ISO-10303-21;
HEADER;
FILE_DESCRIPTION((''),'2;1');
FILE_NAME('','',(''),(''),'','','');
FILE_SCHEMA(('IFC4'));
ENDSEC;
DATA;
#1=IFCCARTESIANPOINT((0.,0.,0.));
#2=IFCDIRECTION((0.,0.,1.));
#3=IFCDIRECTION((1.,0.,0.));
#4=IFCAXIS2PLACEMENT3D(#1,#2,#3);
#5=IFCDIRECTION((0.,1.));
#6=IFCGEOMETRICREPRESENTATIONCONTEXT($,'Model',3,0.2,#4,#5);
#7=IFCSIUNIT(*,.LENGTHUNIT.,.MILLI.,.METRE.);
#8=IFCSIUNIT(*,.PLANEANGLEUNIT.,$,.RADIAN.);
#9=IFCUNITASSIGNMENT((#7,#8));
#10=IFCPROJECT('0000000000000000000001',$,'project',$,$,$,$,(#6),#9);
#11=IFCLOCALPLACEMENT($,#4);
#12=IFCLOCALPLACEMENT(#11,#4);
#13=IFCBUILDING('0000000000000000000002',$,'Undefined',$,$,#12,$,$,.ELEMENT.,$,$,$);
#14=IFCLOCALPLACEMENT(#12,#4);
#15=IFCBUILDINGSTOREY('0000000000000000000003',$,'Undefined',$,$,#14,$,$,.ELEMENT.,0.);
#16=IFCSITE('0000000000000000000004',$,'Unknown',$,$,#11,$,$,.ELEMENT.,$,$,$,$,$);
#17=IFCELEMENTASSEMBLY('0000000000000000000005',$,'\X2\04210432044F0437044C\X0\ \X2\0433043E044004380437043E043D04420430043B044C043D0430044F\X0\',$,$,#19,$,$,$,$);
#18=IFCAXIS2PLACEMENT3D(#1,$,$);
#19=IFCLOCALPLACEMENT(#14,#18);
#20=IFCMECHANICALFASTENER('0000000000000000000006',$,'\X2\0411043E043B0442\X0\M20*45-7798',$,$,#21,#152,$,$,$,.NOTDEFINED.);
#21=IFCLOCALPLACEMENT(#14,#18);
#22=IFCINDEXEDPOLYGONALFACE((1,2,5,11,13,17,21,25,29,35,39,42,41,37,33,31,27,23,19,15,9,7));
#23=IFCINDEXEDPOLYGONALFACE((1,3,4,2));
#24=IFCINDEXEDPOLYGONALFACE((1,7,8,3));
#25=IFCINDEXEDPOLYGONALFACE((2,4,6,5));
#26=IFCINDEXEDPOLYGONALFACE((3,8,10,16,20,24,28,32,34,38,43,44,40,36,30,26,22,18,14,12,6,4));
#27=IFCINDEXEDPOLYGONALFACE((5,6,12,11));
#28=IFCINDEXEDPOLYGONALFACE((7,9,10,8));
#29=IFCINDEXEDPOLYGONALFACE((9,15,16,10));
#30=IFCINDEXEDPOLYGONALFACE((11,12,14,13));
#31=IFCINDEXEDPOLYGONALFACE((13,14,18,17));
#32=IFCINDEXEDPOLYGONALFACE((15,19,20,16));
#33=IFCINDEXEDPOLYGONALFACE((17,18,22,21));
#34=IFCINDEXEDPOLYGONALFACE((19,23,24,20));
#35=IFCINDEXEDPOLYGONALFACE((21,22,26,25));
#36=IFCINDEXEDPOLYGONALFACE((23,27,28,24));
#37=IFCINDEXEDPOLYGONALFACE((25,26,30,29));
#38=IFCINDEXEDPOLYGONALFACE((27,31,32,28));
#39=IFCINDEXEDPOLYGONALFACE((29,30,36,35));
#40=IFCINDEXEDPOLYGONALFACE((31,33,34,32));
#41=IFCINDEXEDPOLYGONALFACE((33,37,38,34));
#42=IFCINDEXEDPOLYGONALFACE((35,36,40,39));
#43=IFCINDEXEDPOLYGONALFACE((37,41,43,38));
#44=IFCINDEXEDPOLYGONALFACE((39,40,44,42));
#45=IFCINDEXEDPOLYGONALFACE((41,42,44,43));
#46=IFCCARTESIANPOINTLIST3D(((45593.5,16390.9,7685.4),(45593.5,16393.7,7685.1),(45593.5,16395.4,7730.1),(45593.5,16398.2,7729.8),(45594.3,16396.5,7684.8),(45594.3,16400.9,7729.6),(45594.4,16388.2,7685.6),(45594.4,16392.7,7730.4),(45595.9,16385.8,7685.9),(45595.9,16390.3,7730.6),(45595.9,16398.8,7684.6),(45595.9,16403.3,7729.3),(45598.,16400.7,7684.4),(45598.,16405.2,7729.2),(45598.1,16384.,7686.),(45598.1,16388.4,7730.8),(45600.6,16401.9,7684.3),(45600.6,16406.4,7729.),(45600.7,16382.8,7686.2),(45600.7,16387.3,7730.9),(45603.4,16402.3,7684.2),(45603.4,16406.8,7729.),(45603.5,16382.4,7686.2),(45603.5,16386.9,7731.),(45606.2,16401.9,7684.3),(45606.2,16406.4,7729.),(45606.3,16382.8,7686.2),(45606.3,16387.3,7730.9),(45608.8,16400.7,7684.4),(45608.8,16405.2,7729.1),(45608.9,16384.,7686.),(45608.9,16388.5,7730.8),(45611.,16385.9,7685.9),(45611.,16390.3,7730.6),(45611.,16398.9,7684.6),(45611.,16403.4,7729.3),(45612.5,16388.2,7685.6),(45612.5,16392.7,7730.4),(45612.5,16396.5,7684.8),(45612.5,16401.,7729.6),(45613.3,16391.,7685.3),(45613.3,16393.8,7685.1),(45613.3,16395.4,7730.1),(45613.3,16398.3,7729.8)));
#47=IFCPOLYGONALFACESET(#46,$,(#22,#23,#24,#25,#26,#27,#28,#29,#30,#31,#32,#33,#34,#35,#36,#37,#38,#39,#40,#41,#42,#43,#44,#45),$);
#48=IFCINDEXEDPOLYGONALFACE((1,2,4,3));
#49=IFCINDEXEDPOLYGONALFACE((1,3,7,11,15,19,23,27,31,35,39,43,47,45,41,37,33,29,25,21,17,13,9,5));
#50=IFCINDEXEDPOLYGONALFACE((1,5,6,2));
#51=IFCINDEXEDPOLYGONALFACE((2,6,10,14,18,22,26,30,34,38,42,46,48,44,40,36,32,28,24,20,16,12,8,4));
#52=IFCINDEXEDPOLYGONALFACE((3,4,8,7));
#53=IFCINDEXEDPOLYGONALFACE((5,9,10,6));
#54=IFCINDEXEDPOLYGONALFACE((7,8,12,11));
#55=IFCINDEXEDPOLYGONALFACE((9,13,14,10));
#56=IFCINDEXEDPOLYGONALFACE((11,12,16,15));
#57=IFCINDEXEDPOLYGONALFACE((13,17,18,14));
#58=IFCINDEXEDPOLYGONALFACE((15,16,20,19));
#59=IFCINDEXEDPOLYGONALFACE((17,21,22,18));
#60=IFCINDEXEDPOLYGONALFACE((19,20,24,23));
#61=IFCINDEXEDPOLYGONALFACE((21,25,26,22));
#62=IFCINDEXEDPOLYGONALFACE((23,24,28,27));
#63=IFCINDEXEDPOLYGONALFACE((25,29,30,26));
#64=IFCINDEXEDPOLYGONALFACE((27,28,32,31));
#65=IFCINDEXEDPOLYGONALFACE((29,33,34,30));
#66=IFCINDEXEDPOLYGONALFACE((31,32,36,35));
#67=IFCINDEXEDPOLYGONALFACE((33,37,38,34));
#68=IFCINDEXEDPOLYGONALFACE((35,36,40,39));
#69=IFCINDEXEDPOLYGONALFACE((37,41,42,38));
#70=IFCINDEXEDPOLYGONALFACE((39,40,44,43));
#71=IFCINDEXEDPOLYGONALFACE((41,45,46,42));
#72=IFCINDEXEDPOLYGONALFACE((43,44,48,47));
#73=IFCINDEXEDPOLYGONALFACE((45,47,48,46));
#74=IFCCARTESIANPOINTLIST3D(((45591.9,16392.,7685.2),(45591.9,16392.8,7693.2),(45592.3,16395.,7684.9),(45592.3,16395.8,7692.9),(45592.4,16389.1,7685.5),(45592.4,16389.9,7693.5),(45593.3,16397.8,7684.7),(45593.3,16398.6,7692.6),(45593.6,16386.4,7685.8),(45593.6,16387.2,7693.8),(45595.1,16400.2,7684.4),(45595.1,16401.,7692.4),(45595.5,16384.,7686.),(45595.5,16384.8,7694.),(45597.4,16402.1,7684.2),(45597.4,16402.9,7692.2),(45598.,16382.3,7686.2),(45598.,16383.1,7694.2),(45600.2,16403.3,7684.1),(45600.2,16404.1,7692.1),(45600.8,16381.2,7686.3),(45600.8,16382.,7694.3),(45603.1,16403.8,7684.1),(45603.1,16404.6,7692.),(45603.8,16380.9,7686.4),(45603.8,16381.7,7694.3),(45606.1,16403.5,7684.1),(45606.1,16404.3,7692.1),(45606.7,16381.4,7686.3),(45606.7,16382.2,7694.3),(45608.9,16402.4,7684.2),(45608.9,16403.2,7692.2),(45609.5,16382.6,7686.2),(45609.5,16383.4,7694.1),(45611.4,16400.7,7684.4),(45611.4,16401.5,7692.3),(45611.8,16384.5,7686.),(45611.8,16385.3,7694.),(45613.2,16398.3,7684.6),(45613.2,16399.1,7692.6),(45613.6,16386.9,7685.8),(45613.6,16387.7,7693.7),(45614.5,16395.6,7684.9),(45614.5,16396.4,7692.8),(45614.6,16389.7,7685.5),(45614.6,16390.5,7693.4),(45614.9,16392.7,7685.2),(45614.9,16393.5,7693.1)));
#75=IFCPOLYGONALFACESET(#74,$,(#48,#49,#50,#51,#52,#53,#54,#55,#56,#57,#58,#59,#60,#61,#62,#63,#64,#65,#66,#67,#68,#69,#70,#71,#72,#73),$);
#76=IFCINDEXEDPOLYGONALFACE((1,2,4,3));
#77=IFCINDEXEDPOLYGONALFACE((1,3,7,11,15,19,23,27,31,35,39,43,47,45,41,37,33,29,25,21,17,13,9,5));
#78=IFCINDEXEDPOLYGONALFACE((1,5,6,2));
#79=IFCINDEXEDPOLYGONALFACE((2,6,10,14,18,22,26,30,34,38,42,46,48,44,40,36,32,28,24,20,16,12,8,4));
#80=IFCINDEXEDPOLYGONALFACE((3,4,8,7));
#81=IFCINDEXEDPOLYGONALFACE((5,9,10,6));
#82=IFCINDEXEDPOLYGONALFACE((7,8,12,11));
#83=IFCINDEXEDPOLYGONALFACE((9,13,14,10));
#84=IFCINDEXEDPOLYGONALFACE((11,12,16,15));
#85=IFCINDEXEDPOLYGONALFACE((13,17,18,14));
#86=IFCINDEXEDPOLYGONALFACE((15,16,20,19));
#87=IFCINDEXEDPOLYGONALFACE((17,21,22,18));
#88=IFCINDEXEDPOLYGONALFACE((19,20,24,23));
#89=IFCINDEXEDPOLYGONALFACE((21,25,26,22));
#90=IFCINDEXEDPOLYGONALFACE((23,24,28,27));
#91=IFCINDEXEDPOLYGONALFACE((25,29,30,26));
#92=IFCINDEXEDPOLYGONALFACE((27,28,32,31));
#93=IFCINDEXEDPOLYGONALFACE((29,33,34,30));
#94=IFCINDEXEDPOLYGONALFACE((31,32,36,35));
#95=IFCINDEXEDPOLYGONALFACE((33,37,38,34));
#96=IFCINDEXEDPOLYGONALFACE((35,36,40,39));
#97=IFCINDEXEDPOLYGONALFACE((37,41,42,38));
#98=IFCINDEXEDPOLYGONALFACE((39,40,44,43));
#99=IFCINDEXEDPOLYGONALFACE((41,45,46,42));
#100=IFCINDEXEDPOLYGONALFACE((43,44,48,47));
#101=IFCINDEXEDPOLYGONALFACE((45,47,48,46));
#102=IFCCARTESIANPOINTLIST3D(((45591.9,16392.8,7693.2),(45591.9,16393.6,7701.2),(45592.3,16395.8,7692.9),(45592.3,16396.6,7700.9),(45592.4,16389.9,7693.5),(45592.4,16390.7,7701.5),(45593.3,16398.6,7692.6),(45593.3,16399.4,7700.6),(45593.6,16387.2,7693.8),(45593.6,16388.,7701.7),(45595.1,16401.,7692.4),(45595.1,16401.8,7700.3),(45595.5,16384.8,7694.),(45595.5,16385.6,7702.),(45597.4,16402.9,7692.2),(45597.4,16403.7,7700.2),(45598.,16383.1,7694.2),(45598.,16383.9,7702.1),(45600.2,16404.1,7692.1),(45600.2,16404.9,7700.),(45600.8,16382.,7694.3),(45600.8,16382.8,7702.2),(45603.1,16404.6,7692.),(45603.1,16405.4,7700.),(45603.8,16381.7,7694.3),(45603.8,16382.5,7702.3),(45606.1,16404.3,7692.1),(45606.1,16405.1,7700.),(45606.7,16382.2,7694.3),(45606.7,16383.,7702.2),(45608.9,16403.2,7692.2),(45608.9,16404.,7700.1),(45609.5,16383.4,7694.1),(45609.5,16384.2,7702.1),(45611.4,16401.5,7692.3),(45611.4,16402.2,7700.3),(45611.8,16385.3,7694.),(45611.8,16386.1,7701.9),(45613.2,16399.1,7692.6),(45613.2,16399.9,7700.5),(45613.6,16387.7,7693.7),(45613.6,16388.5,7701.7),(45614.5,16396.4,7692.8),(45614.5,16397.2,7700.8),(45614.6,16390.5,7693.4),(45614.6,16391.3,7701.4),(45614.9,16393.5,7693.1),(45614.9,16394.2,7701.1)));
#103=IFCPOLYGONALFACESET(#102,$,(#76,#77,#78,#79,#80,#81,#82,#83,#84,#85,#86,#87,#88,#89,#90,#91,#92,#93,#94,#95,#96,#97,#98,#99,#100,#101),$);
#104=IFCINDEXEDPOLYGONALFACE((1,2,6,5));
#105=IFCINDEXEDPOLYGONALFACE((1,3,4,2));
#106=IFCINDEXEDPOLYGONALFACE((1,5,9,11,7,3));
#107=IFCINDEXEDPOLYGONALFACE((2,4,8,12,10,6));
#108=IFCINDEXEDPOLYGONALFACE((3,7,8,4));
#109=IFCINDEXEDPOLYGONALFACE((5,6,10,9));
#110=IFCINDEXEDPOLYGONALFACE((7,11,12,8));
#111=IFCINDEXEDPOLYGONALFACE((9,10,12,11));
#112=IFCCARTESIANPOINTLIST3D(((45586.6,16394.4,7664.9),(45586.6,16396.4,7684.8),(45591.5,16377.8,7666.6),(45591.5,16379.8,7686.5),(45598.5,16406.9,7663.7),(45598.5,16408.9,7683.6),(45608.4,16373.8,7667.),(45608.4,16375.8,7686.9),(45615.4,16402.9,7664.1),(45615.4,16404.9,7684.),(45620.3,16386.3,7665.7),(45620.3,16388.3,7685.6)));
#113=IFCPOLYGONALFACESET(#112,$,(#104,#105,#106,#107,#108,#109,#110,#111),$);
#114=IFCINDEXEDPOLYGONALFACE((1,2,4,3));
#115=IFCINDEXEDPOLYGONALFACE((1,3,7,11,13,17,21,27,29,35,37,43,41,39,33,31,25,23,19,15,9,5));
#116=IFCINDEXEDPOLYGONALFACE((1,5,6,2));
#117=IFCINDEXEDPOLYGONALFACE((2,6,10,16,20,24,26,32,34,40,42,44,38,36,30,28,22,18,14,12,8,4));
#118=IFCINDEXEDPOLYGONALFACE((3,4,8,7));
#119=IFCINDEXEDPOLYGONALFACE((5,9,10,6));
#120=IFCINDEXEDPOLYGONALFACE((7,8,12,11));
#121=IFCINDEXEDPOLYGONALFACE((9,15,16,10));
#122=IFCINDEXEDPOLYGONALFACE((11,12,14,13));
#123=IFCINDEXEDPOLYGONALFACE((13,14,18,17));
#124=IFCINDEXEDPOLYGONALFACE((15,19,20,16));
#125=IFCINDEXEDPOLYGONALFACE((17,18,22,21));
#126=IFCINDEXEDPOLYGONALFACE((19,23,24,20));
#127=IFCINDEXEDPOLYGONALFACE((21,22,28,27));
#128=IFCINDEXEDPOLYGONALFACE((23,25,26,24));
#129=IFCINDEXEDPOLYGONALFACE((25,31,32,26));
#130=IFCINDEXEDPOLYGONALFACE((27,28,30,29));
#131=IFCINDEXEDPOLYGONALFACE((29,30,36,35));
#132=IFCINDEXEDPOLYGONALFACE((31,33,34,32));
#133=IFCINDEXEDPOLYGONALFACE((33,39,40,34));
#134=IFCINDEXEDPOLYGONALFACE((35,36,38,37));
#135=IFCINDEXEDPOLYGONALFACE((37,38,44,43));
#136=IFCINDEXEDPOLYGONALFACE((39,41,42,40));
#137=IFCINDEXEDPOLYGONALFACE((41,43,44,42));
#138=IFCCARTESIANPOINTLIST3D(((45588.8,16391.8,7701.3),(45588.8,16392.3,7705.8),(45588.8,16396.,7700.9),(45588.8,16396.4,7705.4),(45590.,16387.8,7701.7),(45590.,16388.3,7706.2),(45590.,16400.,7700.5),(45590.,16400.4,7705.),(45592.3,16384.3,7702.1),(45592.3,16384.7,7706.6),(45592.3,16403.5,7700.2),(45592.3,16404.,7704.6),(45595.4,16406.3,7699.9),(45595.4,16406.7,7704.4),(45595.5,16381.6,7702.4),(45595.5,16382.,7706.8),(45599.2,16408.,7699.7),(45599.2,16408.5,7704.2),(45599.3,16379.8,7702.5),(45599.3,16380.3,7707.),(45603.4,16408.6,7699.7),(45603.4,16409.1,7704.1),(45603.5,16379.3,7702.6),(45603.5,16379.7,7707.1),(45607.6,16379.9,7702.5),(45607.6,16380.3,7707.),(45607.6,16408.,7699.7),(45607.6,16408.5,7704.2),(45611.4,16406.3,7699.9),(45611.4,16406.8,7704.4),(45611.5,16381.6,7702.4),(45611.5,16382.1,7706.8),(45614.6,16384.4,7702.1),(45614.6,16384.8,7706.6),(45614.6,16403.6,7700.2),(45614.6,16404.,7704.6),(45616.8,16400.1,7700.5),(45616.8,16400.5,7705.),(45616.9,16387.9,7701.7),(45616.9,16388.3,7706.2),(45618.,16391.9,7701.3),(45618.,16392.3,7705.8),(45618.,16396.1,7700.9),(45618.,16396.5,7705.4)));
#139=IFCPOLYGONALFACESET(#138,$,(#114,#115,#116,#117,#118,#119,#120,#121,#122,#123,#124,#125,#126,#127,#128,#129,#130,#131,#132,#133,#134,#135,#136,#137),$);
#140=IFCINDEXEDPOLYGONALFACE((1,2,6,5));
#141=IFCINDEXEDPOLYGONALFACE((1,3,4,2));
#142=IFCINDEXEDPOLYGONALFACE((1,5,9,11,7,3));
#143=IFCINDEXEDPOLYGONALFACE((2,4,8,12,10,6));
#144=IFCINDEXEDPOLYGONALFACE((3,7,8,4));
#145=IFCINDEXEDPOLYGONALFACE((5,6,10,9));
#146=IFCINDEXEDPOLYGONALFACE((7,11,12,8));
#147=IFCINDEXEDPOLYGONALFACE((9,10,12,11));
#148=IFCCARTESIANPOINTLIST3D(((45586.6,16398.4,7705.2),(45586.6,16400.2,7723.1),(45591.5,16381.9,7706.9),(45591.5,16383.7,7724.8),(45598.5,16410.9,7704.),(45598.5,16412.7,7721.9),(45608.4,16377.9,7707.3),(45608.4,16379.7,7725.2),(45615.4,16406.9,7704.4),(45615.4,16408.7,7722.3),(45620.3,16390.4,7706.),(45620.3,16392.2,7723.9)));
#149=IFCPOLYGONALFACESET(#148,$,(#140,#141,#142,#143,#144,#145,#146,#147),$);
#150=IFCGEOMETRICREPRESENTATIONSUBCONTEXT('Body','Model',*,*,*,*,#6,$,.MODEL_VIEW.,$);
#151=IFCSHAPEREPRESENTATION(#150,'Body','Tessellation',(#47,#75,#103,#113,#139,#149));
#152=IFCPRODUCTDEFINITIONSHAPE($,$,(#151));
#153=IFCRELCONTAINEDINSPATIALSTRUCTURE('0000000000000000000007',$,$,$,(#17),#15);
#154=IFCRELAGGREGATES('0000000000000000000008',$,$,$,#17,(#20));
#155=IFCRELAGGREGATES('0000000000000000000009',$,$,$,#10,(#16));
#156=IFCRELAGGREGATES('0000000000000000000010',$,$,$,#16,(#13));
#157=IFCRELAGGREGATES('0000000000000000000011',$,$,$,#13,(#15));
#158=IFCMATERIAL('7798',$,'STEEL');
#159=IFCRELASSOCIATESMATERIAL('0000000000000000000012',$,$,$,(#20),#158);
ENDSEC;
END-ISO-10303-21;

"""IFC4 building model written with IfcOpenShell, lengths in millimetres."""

from ifc_helpers import new_model, si_unit, direction, frame, origin_with_axes, place, context, subcontext, project, spatial, line, arc, indexed_curve, outline, extrude, source, transform, mapped, material, element, aggregate, save


model = new_model("IFC4")

# Units and contexts
model_context = context("Model", 3, precision=0.2, world=origin_with_axes(), true_north=direction((0.0, 1.0)))
body_context = subcontext(model_context, "Body", "Model", "MODEL_VIEW")
ifc_project = project(units=[si_unit("LENGTHUNIT", "METRE", prefix="MILLI"), si_unit("PLANEANGLEUNIT", "RADIAN")], contexts=[model_context])

# Site, building, storey
site_placement = place(None, origin_with_axes())
site = spatial("IfcSite", under=ifc_project, at=site_placement, Name="Unknown", CompositionType="ELEMENT")
building_placement = place(site_placement, origin_with_axes())
building = spatial("IfcBuilding", under=site, at=building_placement, Name="Undefined", CompositionType="ELEMENT")
storey_placement = place(building_placement, origin_with_axes())
storey = spatial("IfcBuildingStorey", under=building, at=storey_placement, Name="Undefined", CompositionType="ELEMENT", Elevation=0.0)

# Element assembly
assembly_1_placement = place(storey_placement, frame((44657.9, 16114.1, 7725.1), z_axis=(0.28473, -0.95385, 0.095385), x_axis=(0.958608, 0.283317, -0.028332)))
assembly_1 = element("IfcElementAssembly", 1, at=assembly_1_placement, inside=storey, Name="Связь горизонтальная")

# Mechanical fastener
ifc_material_1 = material(Name="7798", Category="STEEL")
shared_shape_1 = source(origin_with_axes(), body_context, "Body", "SweptSolid", [
    extrude(outline(indexed_curve([(10.0, 0.0), (0.0, 10.0), (-10.0, 0.0), (0.0, -10.0)], segments=[arc(1, 2, 3), arc(3, 4, 1)])), frame((0.0, 0.0, 12.0), z_axis=(0.0, 0.0, -1.0), x_axis=(0.0, 1.0, 0.0)), (0.0, 0.0, 1.0), 45.0),
    extrude(outline(indexed_curve([(0.0, 11.5), (8.1, 8.1), (11.5, 0.0), (8.1, -8.1), (0.0, -11.5), (-1.0, -11.5), (-11.5, 0.0), (-8.1, 8.1)], segments=[arc(1, 2, 3), arc(3, 4, 5), arc(5, 6, 7), arc(7, 8, 1)])), frame((0.0, 0.0, 12.0), z_axis=(0.0, 0.0, -1.0), x_axis=(0.0, 1.0, 0.0)), (0.0, 0.0, 1.0), 8.0),
    extrude(outline(indexed_curve([(0.0, 11.5), (8.1, 8.1), (11.5, 0.0), (8.1, -8.1), (0.0, -11.5), (-1.0, -11.5), (-11.5, 0.0), (-8.1, 8.1)], segments=[arc(1, 2, 3), arc(3, 4, 5), arc(5, 6, 7), arc(7, 8, 1)])), frame((0.0, 0.0, 4.0), z_axis=(0.0, 0.0, -1.0), x_axis=(0.0, 1.0, 0.0)), (0.0, 0.0, 1.0), 8.0),
    extrude(outline(indexed_curve([(17.3, 0.0), (8.7, 15.0), (-8.7, 15.0), (-17.3, 0.0), (-8.7, -15.0), (8.7, -15.0)], segments=[line(1, 2, 3, 4, 5, 6, 1)])), frame((0.0, 0.0, 32.0), z_axis=(0.0, 0.0, -1.0), x_axis=(0.0, 1.0, 0.0)), (0.0, 0.0, 1.0), 20.0),
    extrude(outline(indexed_curve([(14.8, 0.0), (0.0, 14.8), (-14.8, 0.0), (0.0, -14.8)], segments=[arc(1, 2, 3), arc(3, 4, 1)])), frame((0.0, 0.0, -4.0), z_axis=(0.0, 0.0, -1.0), x_axis=(0.0, 1.0, 0.0)), (0.0, 0.0, 1.0), 4.5),
    extrude(outline(indexed_curve([(17.3, 0.0), (8.7, 15.0), (-8.7, 15.0), (-17.3, 0.0), (-8.7, -15.0), (8.7, -15.0)], segments=[line(1, 2, 3, 4, 5, 6, 1)])), frame((0.0, 0.0, -8.5), z_axis=(0.0, 0.0, -1.0), x_axis=(0.0, 1.0, 0.0)), (0.0, 0.0, 1.0), 18.0),
])
mechanical_fastener_1_placement = place(assembly_1_placement, frame((986.3, 0.0, 0.0), z_axis=(0.0, -1.0, 0.0), x_axis=(-1.0, 0.0, 0.0)))
mechanical_fastener_1 = element("IfcMechanicalFastener", 2, at=mechanical_fastener_1_placement, material=ifc_material_1, Name="БолтM20*45-7798", PredefinedType="NOTDEFINED", context=body_context, shape_type="MappedRepresentation", body=[
    mapped(shared_shape_1, transform((0.0, 0.0, 0.0))),
])
aggregate(assembly_1, [mechanical_fastener_1])

save(model, "model.ifc")
